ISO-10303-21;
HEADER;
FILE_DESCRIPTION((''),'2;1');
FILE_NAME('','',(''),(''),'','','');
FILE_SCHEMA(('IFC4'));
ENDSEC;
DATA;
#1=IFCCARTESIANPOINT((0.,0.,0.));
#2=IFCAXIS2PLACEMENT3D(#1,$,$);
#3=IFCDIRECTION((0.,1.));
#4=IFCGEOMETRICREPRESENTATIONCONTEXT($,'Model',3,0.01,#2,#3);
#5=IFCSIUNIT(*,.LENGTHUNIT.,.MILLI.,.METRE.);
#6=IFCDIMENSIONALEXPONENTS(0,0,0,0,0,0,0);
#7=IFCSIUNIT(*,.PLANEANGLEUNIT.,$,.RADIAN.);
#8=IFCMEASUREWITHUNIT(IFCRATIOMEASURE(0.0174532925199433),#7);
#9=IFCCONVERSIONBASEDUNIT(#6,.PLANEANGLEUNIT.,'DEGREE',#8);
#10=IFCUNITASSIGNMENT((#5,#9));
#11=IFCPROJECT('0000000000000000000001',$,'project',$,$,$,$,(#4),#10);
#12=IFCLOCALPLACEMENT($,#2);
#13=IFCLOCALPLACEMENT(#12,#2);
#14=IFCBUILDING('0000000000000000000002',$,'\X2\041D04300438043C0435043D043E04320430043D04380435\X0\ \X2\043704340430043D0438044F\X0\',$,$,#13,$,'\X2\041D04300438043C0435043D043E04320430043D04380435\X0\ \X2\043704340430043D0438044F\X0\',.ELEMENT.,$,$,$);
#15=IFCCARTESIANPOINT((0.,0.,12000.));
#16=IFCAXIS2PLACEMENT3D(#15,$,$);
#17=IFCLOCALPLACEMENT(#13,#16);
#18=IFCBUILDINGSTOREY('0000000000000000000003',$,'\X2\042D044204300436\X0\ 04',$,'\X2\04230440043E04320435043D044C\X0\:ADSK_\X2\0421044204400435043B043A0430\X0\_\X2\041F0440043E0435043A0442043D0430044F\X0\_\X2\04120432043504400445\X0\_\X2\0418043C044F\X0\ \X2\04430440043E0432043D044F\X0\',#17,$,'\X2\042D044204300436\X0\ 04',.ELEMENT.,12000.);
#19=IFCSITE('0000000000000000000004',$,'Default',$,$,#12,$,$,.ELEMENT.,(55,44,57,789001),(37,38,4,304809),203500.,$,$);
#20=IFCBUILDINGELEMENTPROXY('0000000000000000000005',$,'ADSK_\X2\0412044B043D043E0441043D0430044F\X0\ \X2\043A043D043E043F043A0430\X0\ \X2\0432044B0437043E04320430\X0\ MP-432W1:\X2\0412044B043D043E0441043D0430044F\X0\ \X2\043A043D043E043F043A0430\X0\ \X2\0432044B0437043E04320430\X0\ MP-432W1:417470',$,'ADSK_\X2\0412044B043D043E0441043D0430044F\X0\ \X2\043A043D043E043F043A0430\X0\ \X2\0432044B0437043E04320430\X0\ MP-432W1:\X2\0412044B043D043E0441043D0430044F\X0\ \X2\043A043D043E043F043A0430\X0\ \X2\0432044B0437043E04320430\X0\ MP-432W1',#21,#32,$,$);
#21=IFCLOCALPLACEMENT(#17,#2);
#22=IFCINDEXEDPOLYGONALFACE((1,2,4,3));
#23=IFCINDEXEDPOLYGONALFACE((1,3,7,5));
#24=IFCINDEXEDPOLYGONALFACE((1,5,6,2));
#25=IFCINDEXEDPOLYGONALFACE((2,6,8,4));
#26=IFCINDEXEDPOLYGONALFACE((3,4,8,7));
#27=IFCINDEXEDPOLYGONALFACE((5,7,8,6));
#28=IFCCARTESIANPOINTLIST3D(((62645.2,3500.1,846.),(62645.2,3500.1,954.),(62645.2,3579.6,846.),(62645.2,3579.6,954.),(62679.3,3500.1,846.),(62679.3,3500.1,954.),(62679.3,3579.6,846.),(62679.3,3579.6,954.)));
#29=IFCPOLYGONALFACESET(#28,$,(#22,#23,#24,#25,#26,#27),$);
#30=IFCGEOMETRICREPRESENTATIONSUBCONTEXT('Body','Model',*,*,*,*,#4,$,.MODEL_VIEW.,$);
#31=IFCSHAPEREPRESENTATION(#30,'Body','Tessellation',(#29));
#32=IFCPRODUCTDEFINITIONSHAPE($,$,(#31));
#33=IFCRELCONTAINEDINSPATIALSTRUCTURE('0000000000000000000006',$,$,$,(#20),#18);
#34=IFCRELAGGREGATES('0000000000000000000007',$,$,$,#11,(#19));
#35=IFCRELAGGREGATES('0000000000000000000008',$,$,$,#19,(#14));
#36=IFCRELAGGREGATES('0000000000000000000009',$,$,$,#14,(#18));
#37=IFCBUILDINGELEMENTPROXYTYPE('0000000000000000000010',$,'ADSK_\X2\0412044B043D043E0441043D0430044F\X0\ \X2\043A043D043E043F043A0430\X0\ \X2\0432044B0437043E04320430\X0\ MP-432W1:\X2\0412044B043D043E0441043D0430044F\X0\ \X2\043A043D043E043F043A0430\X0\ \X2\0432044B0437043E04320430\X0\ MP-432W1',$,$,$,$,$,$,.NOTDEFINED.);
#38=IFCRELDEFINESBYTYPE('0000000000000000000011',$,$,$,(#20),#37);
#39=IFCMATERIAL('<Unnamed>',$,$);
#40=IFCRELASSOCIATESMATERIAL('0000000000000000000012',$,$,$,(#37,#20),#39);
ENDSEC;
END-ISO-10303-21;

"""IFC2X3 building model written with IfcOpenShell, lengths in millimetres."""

from ifc_helpers import new_model, entity, si_unit, converted_unit, direction, frame, origin, origin_2d_with_axis, place, context, subcontext, project, spatial, rectangle, extrude, source, transform, mapped, material, type_object, type_shapes, element, save


model = new_model("IFC2X3")

# Units and contexts
model_context = context("Model", 3, precision=0.01, world=origin(), true_north=direction((0.0, 1.0)))
body_context = subcontext(model_context, "Body", "Model", "MODEL_VIEW")
ifc_project = project(units=[si_unit("LENGTHUNIT", "METRE", prefix="MILLI"), converted_unit("PLANEANGLEUNIT", "DEGREE", entity("IfcRatioMeasure", 0.0174532925199433), si_unit("PLANEANGLEUNIT", "RADIAN"), dimensions=[0, 0, 0, 0, 0, 0, 0])], contexts=[model_context])

# Site, building, storey
site_placement = place(None, origin())
site = spatial("IfcSite", under=ifc_project, at=site_placement, Name="Default", CompositionType="ELEMENT", RefLatitude=(55, 44, 57, 789001), RefLongitude=(37, 38, 4, 304809), RefElevation=203500.0)
building_placement = place(site_placement, origin())
building = spatial("IfcBuilding", under=site, at=building_placement, Name="Наименование здания", LongName="Наименование здания", CompositionType="ELEMENT")
storey_placement = place(building_placement, frame((0.0, 0.0, 12000.0)))
storey = spatial("IfcBuildingStorey", under=building, at=storey_placement, Name="Этаж 04", ObjectType="Уровень:ADSK_Стрелка_Проектная_Вверх_Имя уровня", LongName="Этаж 04", CompositionType="ELEMENT", Elevation=12000.0)

# Building element proxy
ifc_material = material(Name="<Unnamed>")
building_element_proxy_type_1 = type_object("IfcBuildingElementProxyType", Name="ADSK_Выносная кнопка вызова MP-432W1:Выносная кнопка вызова MP-432W1", PredefinedType="NOTDEFINED", material=ifc_material)
shared_shape_1 = source(origin(), body_context, "Body", "SweptSolid", [
    extrude(rectangle(XDim=79.5, YDim=34.1, at=origin_2d_with_axis()), frame((0.0, 15.0, -54.0), z_axis=(0.0, 0.0, 1.0), x_axis=(-1.0, 0.0, 0.0)), (0.0, 0.0, 1.0), 108.0),
])
type_shapes(building_element_proxy_type_1, [shared_shape_1])
for number, where, z_axis, x_axis, name in (
    (1, (62677.2, 3539.8, 900.0), (0.0, 0.0, 1.0), (0.0, 1.0, 0.0), "ADSK_Выносная кнопка вызова MP-432W1:Выносная кнопка вызова MP-432W1:417470"),
):
    element("IfcBuildingElementProxy", number, at=place(storey_placement, frame(where, z_axis=z_axis, x_axis=x_axis)), inside=storey, type_object=building_element_proxy_type_1, material=ifc_material, Name=name, ObjectType="ADSK_Выносная кнопка вызова MP-432W1:Выносная кнопка вызова MP-432W1", context=body_context, shape_type="MappedRepresentation", body=[
        mapped(shared_shape_1, transform((0.0, 0.0, 0.0), scale=1.0)),
    ])

save(model, "model.ifc")
